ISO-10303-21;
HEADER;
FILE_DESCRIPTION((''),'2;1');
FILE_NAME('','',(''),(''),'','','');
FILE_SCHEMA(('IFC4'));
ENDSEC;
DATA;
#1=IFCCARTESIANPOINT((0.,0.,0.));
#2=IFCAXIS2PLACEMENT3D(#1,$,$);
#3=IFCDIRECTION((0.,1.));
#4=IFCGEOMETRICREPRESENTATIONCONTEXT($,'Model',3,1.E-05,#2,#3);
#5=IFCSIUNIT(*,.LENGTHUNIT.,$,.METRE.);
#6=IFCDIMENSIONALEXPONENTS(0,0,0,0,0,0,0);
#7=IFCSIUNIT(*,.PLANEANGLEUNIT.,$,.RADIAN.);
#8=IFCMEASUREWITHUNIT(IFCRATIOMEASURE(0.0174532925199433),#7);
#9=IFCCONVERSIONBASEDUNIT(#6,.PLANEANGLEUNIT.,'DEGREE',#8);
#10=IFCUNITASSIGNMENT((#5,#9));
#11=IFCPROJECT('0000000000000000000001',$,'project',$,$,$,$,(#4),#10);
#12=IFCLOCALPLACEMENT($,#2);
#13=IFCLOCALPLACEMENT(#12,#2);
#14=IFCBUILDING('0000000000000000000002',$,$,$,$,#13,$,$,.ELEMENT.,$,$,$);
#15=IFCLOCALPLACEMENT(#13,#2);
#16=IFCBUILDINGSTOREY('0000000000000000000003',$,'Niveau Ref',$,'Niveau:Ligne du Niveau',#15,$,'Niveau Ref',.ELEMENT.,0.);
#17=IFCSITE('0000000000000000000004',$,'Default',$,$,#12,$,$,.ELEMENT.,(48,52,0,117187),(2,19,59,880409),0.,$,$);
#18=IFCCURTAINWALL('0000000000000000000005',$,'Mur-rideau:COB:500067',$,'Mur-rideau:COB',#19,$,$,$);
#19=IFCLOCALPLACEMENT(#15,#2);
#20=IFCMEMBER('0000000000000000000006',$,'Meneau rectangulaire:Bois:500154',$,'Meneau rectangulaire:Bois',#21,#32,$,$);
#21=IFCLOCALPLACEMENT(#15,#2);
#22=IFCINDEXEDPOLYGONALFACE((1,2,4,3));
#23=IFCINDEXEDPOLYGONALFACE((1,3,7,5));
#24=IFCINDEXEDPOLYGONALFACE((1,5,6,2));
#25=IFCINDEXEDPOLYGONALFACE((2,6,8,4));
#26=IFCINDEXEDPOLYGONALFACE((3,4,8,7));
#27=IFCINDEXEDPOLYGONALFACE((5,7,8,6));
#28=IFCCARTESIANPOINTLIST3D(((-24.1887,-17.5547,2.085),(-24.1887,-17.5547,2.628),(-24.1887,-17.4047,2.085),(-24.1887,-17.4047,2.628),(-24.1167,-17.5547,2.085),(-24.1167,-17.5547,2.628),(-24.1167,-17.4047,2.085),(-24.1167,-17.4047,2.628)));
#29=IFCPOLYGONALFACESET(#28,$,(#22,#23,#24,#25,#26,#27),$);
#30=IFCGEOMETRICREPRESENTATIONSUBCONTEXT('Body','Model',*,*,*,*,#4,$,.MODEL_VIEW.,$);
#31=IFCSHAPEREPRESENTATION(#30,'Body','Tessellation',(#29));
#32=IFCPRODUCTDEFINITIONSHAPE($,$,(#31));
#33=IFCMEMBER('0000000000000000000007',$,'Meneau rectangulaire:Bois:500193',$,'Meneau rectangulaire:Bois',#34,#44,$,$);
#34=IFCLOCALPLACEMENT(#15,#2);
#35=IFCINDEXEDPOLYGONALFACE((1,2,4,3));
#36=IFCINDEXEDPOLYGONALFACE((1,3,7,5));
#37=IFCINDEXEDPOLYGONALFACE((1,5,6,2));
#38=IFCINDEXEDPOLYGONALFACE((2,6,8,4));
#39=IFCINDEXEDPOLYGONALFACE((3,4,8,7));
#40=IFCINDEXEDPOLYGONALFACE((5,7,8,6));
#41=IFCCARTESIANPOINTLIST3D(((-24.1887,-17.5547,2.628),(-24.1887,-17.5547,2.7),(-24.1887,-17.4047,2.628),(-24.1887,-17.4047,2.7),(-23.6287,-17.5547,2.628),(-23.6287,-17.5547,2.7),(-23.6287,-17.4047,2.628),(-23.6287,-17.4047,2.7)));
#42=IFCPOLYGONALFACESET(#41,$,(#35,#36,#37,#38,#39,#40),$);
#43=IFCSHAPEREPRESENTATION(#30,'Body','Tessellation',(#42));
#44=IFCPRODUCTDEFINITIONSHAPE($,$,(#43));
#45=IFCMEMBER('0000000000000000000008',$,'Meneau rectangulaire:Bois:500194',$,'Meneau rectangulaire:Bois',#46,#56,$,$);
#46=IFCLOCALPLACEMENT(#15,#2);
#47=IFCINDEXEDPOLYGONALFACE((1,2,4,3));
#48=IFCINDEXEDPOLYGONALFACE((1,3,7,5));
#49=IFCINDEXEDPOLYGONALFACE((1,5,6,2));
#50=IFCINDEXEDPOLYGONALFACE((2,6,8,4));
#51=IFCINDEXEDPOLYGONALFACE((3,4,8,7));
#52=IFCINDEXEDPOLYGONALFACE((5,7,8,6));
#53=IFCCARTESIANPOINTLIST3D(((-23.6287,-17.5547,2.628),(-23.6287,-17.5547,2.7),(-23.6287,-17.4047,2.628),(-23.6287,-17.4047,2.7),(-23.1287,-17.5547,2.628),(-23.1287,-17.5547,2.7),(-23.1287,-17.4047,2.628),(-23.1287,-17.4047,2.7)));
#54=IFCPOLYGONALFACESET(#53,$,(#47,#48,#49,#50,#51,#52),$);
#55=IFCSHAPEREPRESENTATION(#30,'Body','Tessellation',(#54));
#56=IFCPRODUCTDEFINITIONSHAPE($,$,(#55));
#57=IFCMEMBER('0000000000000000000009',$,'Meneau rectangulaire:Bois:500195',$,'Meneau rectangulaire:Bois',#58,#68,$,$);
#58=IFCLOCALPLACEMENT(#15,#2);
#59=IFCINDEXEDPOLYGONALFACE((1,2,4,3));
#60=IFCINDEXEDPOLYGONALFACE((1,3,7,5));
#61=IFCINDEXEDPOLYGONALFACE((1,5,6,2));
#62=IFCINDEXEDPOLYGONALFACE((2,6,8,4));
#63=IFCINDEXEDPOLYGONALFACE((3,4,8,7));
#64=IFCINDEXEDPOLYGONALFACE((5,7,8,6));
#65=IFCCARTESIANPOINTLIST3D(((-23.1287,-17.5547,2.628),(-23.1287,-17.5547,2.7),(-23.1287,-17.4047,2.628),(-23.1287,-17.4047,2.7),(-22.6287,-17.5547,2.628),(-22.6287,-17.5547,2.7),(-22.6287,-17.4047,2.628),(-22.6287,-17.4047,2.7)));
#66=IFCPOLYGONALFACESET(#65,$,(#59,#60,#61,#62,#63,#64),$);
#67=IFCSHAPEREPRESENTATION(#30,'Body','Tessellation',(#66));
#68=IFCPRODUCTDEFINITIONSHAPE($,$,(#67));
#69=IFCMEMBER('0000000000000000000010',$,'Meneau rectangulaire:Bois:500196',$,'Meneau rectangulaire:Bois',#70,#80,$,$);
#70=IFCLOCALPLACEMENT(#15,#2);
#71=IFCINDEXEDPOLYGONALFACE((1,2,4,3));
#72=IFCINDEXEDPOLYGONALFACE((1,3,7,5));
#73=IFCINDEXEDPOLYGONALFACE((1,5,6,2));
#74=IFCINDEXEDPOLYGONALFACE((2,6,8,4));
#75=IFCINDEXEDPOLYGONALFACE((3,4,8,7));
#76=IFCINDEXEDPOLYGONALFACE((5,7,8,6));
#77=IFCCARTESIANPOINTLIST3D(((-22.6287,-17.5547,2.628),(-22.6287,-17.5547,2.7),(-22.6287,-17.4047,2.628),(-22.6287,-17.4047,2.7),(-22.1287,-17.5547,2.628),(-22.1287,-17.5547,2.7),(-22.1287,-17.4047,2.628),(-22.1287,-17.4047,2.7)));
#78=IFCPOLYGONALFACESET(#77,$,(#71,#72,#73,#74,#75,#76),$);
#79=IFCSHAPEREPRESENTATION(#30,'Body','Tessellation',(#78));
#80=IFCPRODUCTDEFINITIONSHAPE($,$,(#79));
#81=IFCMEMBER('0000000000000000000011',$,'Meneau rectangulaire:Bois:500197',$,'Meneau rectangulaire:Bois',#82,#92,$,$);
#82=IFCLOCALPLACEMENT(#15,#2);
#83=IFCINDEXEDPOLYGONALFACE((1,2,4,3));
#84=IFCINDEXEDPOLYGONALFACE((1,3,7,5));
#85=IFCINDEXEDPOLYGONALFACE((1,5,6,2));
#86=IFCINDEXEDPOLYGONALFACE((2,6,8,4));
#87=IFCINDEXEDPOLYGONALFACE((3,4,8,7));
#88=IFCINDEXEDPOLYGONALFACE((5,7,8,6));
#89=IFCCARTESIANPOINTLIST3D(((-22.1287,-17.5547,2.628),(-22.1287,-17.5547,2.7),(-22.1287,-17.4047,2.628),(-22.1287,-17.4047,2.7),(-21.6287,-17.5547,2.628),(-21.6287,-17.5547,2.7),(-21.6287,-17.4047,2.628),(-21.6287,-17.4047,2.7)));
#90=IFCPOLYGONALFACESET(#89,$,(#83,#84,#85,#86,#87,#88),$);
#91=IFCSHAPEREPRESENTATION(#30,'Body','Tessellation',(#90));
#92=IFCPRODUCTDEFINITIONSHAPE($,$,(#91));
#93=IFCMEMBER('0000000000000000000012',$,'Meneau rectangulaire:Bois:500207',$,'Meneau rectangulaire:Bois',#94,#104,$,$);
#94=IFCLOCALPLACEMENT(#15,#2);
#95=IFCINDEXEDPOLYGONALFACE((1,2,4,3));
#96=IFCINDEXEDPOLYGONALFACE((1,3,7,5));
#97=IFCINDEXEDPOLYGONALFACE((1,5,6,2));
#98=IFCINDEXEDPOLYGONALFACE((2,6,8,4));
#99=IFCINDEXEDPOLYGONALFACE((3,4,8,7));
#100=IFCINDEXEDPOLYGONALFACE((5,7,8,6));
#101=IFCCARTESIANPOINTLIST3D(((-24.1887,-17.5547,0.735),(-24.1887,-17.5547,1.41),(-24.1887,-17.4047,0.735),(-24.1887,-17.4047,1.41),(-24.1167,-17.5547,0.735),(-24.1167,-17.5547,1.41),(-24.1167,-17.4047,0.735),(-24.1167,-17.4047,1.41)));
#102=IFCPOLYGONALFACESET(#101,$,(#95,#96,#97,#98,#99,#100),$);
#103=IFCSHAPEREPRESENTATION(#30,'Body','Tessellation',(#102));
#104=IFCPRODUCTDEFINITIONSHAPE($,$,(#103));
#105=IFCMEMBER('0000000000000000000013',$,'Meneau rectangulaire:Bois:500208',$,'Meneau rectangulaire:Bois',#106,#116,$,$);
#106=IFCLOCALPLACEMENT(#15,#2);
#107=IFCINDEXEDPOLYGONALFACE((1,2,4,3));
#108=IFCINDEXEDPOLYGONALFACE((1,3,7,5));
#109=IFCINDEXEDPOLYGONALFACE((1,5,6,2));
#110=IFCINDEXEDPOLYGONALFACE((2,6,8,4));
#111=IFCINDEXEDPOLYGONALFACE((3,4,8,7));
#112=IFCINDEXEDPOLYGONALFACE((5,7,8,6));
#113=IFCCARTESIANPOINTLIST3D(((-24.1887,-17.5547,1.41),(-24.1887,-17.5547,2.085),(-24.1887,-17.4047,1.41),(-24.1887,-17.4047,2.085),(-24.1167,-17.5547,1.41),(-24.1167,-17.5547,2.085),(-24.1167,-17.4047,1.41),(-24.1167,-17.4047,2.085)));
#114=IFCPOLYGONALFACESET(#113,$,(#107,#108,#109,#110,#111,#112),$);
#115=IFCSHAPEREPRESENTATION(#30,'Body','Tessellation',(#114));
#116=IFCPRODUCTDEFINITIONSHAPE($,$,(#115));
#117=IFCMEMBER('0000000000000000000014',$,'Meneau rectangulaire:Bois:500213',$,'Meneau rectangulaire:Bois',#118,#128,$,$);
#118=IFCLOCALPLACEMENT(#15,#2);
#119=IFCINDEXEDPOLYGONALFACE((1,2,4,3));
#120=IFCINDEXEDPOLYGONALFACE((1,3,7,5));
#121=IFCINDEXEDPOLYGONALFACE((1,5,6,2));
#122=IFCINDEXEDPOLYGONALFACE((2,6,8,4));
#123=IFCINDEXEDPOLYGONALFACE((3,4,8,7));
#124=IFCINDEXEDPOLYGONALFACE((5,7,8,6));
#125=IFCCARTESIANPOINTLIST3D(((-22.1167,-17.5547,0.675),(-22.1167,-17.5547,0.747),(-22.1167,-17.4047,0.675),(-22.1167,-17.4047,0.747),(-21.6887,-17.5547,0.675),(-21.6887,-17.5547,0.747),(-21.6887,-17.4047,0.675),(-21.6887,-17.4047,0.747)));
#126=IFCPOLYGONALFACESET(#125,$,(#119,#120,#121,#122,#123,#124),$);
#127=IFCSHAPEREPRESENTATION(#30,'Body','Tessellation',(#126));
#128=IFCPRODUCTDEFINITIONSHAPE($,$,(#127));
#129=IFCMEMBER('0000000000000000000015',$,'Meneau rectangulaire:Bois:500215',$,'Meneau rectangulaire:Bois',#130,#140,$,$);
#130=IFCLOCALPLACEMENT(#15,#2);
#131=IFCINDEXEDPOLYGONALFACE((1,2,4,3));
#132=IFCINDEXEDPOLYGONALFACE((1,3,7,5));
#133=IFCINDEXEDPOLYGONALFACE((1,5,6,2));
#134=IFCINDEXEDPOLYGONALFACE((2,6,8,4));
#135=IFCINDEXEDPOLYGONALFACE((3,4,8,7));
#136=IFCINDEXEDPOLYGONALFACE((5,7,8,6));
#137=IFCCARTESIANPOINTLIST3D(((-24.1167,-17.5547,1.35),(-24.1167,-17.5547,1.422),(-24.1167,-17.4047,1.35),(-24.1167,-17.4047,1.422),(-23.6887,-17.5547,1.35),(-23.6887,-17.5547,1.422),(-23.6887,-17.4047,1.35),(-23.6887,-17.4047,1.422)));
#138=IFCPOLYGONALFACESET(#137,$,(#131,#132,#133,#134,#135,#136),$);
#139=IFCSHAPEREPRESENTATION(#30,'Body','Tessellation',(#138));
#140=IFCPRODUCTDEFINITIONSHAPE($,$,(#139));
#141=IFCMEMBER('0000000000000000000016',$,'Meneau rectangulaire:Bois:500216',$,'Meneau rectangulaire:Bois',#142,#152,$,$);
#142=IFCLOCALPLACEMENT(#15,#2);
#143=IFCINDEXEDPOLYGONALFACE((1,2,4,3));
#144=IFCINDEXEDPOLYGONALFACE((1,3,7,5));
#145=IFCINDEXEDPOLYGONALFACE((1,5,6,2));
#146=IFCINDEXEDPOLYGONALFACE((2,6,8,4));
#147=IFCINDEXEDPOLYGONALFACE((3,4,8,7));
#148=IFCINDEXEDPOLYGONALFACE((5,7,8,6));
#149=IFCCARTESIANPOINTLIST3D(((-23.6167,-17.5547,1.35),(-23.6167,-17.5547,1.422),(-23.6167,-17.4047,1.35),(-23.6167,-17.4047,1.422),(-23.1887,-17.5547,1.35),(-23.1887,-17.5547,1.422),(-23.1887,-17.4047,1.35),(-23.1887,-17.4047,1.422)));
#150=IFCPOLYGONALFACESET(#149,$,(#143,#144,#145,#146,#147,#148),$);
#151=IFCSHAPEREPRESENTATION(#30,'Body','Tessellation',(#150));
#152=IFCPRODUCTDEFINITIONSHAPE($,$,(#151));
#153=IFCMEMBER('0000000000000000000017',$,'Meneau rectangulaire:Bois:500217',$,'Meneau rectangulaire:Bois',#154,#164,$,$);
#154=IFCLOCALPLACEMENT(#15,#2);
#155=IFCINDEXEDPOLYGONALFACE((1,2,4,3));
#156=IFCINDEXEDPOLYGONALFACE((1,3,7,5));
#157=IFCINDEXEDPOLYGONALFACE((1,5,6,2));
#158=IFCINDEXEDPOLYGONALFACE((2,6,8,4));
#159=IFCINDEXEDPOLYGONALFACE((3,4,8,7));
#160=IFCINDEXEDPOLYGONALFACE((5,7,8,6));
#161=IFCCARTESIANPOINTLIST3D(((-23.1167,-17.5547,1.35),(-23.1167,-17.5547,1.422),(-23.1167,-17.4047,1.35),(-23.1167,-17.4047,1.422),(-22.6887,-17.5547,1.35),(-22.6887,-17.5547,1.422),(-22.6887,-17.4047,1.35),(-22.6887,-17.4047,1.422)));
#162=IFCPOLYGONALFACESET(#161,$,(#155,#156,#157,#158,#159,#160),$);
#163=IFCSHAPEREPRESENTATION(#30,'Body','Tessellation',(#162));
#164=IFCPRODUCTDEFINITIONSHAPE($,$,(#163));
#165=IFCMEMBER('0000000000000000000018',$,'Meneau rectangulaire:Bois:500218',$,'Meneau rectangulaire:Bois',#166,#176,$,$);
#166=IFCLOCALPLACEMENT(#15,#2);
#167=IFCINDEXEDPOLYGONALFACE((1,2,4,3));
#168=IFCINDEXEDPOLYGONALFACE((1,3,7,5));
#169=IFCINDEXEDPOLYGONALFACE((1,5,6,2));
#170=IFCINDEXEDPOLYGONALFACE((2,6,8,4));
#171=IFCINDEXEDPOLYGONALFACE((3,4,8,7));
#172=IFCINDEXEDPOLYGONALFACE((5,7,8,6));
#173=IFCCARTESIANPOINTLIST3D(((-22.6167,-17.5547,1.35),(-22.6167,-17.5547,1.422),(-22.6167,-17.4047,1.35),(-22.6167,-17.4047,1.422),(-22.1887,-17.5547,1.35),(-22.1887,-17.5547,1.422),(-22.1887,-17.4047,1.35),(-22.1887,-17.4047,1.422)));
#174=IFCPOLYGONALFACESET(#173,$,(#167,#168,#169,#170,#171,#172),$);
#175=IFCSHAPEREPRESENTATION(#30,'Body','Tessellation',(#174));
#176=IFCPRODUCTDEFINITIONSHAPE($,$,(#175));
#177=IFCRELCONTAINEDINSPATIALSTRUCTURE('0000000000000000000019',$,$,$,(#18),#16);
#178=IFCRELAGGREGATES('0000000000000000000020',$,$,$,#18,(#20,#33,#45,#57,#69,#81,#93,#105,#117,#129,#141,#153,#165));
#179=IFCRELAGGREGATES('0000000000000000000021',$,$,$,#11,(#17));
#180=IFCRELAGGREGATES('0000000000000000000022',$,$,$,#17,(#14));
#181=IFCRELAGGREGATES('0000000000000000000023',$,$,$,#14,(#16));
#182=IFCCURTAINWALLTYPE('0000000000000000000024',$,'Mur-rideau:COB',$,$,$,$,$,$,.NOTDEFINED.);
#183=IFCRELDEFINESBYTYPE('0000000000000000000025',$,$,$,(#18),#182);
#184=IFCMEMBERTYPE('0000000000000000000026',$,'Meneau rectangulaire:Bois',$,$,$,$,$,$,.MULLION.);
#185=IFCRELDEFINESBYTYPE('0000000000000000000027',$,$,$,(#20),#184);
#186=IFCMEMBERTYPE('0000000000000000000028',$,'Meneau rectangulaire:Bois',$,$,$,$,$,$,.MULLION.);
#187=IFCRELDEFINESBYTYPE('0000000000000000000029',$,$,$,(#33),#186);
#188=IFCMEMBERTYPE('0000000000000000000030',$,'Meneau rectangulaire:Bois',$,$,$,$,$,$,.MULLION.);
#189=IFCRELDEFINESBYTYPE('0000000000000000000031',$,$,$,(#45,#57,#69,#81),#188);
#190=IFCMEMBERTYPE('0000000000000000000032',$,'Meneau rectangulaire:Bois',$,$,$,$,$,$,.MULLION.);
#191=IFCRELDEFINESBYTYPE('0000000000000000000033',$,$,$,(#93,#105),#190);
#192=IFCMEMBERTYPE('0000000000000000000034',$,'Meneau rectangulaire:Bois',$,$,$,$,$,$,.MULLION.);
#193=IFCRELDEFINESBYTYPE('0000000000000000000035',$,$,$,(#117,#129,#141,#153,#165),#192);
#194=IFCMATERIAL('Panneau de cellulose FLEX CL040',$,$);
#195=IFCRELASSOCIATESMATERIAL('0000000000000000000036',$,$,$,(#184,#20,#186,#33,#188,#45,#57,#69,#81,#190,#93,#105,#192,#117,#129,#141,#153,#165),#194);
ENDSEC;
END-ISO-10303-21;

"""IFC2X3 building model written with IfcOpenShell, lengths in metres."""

from ifc_helpers import new_model, entity, si_unit, converted_unit, direction, frame, origin, origin_2d_with_axis, place, context, subcontext, project, spatial, rectangle, extrude, source, transform, mapped, material, type_object, type_shapes, element, aggregate, save


model = new_model("IFC2X3")

# Units and contexts
model_context = context("Model", 3, precision=1e-05, world=origin(), true_north=direction((0.0, 1.0)))
body_context = subcontext(model_context, "Body", "Model", "MODEL_VIEW")
ifc_project = project(units=[si_unit("LENGTHUNIT", "METRE"), converted_unit("PLANEANGLEUNIT", "DEGREE", entity("IfcRatioMeasure", 0.0174532925199433), si_unit("PLANEANGLEUNIT", "RADIAN"), dimensions=[0, 0, 0, 0, 0, 0, 0])], contexts=[model_context])

# Site, building, storey
site_placement = place(None, origin())
site = spatial("IfcSite", under=ifc_project, at=site_placement, Name="Default", CompositionType="ELEMENT", RefLatitude=(48, 52, 0, 117187), RefLongitude=(2, 19, 59, 880409), RefElevation=0.0)
building_placement = place(site_placement, origin())
building = spatial("IfcBuilding", under=site, at=building_placement, CompositionType="ELEMENT")
storey_placement = place(building_placement, origin())
storey = spatial("IfcBuildingStorey", under=building, at=storey_placement, Name="Niveau Ref", ObjectType="Niveau:Ligne du Niveau", LongName="Niveau Ref", CompositionType="ELEMENT", Elevation=0.0)

# Curtain wall, members
curtain_wall_type = type_object("IfcCurtainWallType", Name="Mur-rideau:COB", PredefinedType="NOTDEFINED")
curtain_wall_placement = place(storey_placement, origin())
curtain_wall = element("IfcCurtainWall", 1, at=curtain_wall_placement, inside=storey, type_object=curtain_wall_type, Name="Mur-rideau:COB:500067", ObjectType="Mur-rideau:COB")
ifc_material = material(Name="Panneau de cellulose FLEX CL040")
member_type_1 = type_object("IfcMemberType", Name="Meneau rectangulaire:Bois", PredefinedType="MULLION", material=ifc_material)
shared_shape_1 = source(origin(), body_context, "Body", "SweptSolid", [
    extrude(rectangle(XDim=0.15, YDim=0.072, at=origin_2d_with_axis()), frame((-0.036, 0.0, -0.543), z_axis=(0.0, 0.0, 1.0), x_axis=(0.0, -1.0, 0.0)), (0.0, 0.0, 1.0), 0.543),
])
type_shapes(member_type_1, [shared_shape_1])
member_1_placement = place(storey_placement, frame((-24.1887, -17.4797, 2.628), z_axis=(0.0, 0.0, 1.0), x_axis=(-1.0, 0.0, 0.0)))
member_1 = element("IfcMember", 2, at=member_1_placement, type_object=member_type_1, material=ifc_material, Name="Meneau rectangulaire:Bois:500154", ObjectType="Meneau rectangulaire:Bois", context=body_context, shape_type="MappedRepresentation", body=[
    mapped(shared_shape_1, transform((0.0, 0.0, 0.0), scale=1.0)),
])
member_type_2 = type_object("IfcMemberType", Name="Meneau rectangulaire:Bois", PredefinedType="MULLION", material=ifc_material)
shared_shape_2 = source(origin(), body_context, "Body", "SweptSolid", [
    extrude(rectangle(XDim=0.15, YDim=0.072, at=origin_2d_with_axis()), frame((-0.036, 0.0, -0.56), z_axis=(0.0, 0.0, 1.0), x_axis=(0.0, -1.0, 0.0)), (0.0, 0.0, 1.0), 0.56),
])
type_shapes(member_type_2, [shared_shape_2])
member_2_placement = place(storey_placement, frame((-23.6287, -17.4797, 2.7), z_axis=(1.0, 0.0, 0.0), x_axis=(0.0, 0.0, 1.0)))
member_2 = element("IfcMember", 3, at=member_2_placement, type_object=member_type_2, material=ifc_material, Name="Meneau rectangulaire:Bois:500193", ObjectType="Meneau rectangulaire:Bois", context=body_context, shape_type="MappedRepresentation", body=[
    mapped(shared_shape_2, transform((0.0, 0.0, 0.0), scale=1.0)),
])
member_type_3 = type_object("IfcMemberType", Name="Meneau rectangulaire:Bois", PredefinedType="MULLION", material=ifc_material)
shared_shape_3 = source(origin(), body_context, "Body", "SweptSolid", [
    extrude(rectangle(XDim=0.15, YDim=0.072, at=origin_2d_with_axis()), frame((-0.036, 0.0, -0.5), z_axis=(0.0, 0.0, 1.0), x_axis=(0.0, -1.0, 0.0)), (0.0, 0.0, 1.0), 0.5),
])
type_shapes(member_type_3, [shared_shape_3])
member_3_placement = place(storey_placement, frame((-23.1287, -17.4797, 2.7), z_axis=(1.0, 0.0, 0.0), x_axis=(0.0, 0.0, 1.0)))
member_3 = element("IfcMember", 4, at=member_3_placement, type_object=member_type_3, material=ifc_material, Name="Meneau rectangulaire:Bois:500194", ObjectType="Meneau rectangulaire:Bois", context=body_context, shape_type="MappedRepresentation", body=[
    mapped(shared_shape_3, transform((0.0, 0.0, 0.0), scale=1.0)),
])
member_4_placement = place(storey_placement, frame((-22.6287, -17.4797, 2.7), z_axis=(1.0, 0.0, 0.0), x_axis=(0.0, 0.0, 1.0)))
member_4 = element("IfcMember", 5, at=member_4_placement, type_object=member_type_3, material=ifc_material, Name="Meneau rectangulaire:Bois:500195", ObjectType="Meneau rectangulaire:Bois", context=body_context, shape_type="MappedRepresentation", body=[
    mapped(shared_shape_3, transform((0.0, 0.0, 0.0), scale=1.0)),
])
member_5_placement = place(storey_placement, frame((-22.1287, -17.4797, 2.7), z_axis=(1.0, 0.0, 0.0), x_axis=(0.0, 0.0, 1.0)))
member_5 = element("IfcMember", 6, at=member_5_placement, type_object=member_type_3, material=ifc_material, Name="Meneau rectangulaire:Bois:500196", ObjectType="Meneau rectangulaire:Bois", context=body_context, shape_type="MappedRepresentation", body=[
    mapped(shared_shape_3, transform((0.0, 0.0, 0.0), scale=1.0)),
])
member_6_placement = place(storey_placement, frame((-21.6287, -17.4797, 2.7), z_axis=(1.0, 0.0, 0.0), x_axis=(0.0, 0.0, 1.0)))
member_6 = element("IfcMember", 7, at=member_6_placement, type_object=member_type_3, material=ifc_material, Name="Meneau rectangulaire:Bois:500197", ObjectType="Meneau rectangulaire:Bois", context=body_context, shape_type="MappedRepresentation", body=[
    mapped(shared_shape_3, transform((0.0, 0.0, 0.0), scale=1.0)),
])
member_type_4 = type_object("IfcMemberType", Name="Meneau rectangulaire:Bois", PredefinedType="MULLION", material=ifc_material)
shared_shape_4 = source(origin(), body_context, "Body", "SweptSolid", [
    extrude(rectangle(XDim=0.15, YDim=0.072, at=origin_2d_with_axis()), frame((-0.036, 0.0, -0.675), z_axis=(0.0, 0.0, 1.0), x_axis=(0.0, -1.0, 0.0)), (0.0, 0.0, 1.0), 0.675),
])
type_shapes(member_type_4, [shared_shape_4])
member_7_placement = place(storey_placement, frame((-24.1887, -17.4797, 1.41), z_axis=(0.0, 0.0, 1.0), x_axis=(-1.0, 0.0, 0.0)))
member_7 = element("IfcMember", 8, at=member_7_placement, type_object=member_type_4, material=ifc_material, Name="Meneau rectangulaire:Bois:500207", ObjectType="Meneau rectangulaire:Bois", context=body_context, shape_type="MappedRepresentation", body=[
    mapped(shared_shape_4, transform((0.0, 0.0, 0.0), scale=1.0)),
])
member_8_placement = place(storey_placement, frame((-24.1887, -17.4797, 2.085), z_axis=(0.0, 0.0, 1.0), x_axis=(-1.0, 0.0, 0.0)))
member_8 = element("IfcMember", 9, at=member_8_placement, type_object=member_type_4, material=ifc_material, Name="Meneau rectangulaire:Bois:500208", ObjectType="Meneau rectangulaire:Bois", context=body_context, shape_type="MappedRepresentation", body=[
    mapped(shared_shape_4, transform((0.0, 0.0, 0.0), scale=1.0)),
])
member_type_5 = type_object("IfcMemberType", Name="Meneau rectangulaire:Bois", PredefinedType="MULLION", material=ifc_material)
shared_shape_5 = source(origin(), body_context, "Body", "SweptSolid", [
    extrude(rectangle(XDim=0.15, YDim=0.072, at=origin_2d_with_axis()), frame((-0.024, 0.0, -0.428), z_axis=(0.0, 0.0, 1.0), x_axis=(0.0, -1.0, 0.0)), (0.0, 0.0, 1.0), 0.428),
])
type_shapes(member_type_5, [shared_shape_5])
member_9_placement = place(storey_placement, frame((-21.6887, -17.4797, 0.735), z_axis=(1.0, 0.0, 0.0), x_axis=(0.0, 0.0, 1.0)))
member_9 = element("IfcMember", 10, at=member_9_placement, type_object=member_type_5, material=ifc_material, Name="Meneau rectangulaire:Bois:500213", ObjectType="Meneau rectangulaire:Bois", context=body_context, shape_type="MappedRepresentation", body=[
    mapped(shared_shape_5, transform((0.0, 0.0, 0.0), scale=1.0)),
])
member_10_placement = place(storey_placement, frame((-23.6887, -17.4797, 1.41), z_axis=(1.0, 0.0, 0.0), x_axis=(0.0, 0.0, 1.0)))
member_10 = element("IfcMember", 11, at=member_10_placement, type_object=member_type_5, material=ifc_material, Name="Meneau rectangulaire:Bois:500215", ObjectType="Meneau rectangulaire:Bois", context=body_context, shape_type="MappedRepresentation", body=[
    mapped(shared_shape_5, transform((0.0, 0.0, 0.0), scale=1.0)),
])
member_11_placement = place(storey_placement, frame((-23.1887, -17.4797, 1.41), z_axis=(1.0, 0.0, 0.0), x_axis=(0.0, 0.0, 1.0)))
member_11 = element("IfcMember", 12, at=member_11_placement, type_object=member_type_5, material=ifc_material, Name="Meneau rectangulaire:Bois:500216", ObjectType="Meneau rectangulaire:Bois", context=body_context, shape_type="MappedRepresentation", body=[
    mapped(shared_shape_5, transform((0.0, 0.0, 0.0), scale=1.0)),
])
member_12_placement = place(storey_placement, frame((-22.6887, -17.4797, 1.41), z_axis=(1.0, 0.0, 0.0), x_axis=(0.0, 0.0, 1.0)))
member_12 = element("IfcMember", 13, at=member_12_placement, type_object=member_type_5, material=ifc_material, Name="Meneau rectangulaire:Bois:500217", ObjectType="Meneau rectangulaire:Bois", context=body_context, shape_type="MappedRepresentation", body=[
    mapped(shared_shape_5, transform((0.0, 0.0, 0.0), scale=1.0)),
])
member_13_placement = place(storey_placement, frame((-22.1887, -17.4797, 1.41), z_axis=(1.0, 0.0, 0.0), x_axis=(0.0, 0.0, 1.0)))
member_13 = element("IfcMember", 14, at=member_13_placement, type_object=member_type_5, material=ifc_material, Name="Meneau rectangulaire:Bois:500218", ObjectType="Meneau rectangulaire:Bois", context=body_context, shape_type="MappedRepresentation", body=[
    mapped(shared_shape_5, transform((0.0, 0.0, 0.0), scale=1.0)),
])
aggregate(curtain_wall, [member_1, member_2, member_3, member_4, member_5, member_6, member_7, member_8, member_9, member_10, member_11, member_12, member_13])

save(model, "model.ifc")
